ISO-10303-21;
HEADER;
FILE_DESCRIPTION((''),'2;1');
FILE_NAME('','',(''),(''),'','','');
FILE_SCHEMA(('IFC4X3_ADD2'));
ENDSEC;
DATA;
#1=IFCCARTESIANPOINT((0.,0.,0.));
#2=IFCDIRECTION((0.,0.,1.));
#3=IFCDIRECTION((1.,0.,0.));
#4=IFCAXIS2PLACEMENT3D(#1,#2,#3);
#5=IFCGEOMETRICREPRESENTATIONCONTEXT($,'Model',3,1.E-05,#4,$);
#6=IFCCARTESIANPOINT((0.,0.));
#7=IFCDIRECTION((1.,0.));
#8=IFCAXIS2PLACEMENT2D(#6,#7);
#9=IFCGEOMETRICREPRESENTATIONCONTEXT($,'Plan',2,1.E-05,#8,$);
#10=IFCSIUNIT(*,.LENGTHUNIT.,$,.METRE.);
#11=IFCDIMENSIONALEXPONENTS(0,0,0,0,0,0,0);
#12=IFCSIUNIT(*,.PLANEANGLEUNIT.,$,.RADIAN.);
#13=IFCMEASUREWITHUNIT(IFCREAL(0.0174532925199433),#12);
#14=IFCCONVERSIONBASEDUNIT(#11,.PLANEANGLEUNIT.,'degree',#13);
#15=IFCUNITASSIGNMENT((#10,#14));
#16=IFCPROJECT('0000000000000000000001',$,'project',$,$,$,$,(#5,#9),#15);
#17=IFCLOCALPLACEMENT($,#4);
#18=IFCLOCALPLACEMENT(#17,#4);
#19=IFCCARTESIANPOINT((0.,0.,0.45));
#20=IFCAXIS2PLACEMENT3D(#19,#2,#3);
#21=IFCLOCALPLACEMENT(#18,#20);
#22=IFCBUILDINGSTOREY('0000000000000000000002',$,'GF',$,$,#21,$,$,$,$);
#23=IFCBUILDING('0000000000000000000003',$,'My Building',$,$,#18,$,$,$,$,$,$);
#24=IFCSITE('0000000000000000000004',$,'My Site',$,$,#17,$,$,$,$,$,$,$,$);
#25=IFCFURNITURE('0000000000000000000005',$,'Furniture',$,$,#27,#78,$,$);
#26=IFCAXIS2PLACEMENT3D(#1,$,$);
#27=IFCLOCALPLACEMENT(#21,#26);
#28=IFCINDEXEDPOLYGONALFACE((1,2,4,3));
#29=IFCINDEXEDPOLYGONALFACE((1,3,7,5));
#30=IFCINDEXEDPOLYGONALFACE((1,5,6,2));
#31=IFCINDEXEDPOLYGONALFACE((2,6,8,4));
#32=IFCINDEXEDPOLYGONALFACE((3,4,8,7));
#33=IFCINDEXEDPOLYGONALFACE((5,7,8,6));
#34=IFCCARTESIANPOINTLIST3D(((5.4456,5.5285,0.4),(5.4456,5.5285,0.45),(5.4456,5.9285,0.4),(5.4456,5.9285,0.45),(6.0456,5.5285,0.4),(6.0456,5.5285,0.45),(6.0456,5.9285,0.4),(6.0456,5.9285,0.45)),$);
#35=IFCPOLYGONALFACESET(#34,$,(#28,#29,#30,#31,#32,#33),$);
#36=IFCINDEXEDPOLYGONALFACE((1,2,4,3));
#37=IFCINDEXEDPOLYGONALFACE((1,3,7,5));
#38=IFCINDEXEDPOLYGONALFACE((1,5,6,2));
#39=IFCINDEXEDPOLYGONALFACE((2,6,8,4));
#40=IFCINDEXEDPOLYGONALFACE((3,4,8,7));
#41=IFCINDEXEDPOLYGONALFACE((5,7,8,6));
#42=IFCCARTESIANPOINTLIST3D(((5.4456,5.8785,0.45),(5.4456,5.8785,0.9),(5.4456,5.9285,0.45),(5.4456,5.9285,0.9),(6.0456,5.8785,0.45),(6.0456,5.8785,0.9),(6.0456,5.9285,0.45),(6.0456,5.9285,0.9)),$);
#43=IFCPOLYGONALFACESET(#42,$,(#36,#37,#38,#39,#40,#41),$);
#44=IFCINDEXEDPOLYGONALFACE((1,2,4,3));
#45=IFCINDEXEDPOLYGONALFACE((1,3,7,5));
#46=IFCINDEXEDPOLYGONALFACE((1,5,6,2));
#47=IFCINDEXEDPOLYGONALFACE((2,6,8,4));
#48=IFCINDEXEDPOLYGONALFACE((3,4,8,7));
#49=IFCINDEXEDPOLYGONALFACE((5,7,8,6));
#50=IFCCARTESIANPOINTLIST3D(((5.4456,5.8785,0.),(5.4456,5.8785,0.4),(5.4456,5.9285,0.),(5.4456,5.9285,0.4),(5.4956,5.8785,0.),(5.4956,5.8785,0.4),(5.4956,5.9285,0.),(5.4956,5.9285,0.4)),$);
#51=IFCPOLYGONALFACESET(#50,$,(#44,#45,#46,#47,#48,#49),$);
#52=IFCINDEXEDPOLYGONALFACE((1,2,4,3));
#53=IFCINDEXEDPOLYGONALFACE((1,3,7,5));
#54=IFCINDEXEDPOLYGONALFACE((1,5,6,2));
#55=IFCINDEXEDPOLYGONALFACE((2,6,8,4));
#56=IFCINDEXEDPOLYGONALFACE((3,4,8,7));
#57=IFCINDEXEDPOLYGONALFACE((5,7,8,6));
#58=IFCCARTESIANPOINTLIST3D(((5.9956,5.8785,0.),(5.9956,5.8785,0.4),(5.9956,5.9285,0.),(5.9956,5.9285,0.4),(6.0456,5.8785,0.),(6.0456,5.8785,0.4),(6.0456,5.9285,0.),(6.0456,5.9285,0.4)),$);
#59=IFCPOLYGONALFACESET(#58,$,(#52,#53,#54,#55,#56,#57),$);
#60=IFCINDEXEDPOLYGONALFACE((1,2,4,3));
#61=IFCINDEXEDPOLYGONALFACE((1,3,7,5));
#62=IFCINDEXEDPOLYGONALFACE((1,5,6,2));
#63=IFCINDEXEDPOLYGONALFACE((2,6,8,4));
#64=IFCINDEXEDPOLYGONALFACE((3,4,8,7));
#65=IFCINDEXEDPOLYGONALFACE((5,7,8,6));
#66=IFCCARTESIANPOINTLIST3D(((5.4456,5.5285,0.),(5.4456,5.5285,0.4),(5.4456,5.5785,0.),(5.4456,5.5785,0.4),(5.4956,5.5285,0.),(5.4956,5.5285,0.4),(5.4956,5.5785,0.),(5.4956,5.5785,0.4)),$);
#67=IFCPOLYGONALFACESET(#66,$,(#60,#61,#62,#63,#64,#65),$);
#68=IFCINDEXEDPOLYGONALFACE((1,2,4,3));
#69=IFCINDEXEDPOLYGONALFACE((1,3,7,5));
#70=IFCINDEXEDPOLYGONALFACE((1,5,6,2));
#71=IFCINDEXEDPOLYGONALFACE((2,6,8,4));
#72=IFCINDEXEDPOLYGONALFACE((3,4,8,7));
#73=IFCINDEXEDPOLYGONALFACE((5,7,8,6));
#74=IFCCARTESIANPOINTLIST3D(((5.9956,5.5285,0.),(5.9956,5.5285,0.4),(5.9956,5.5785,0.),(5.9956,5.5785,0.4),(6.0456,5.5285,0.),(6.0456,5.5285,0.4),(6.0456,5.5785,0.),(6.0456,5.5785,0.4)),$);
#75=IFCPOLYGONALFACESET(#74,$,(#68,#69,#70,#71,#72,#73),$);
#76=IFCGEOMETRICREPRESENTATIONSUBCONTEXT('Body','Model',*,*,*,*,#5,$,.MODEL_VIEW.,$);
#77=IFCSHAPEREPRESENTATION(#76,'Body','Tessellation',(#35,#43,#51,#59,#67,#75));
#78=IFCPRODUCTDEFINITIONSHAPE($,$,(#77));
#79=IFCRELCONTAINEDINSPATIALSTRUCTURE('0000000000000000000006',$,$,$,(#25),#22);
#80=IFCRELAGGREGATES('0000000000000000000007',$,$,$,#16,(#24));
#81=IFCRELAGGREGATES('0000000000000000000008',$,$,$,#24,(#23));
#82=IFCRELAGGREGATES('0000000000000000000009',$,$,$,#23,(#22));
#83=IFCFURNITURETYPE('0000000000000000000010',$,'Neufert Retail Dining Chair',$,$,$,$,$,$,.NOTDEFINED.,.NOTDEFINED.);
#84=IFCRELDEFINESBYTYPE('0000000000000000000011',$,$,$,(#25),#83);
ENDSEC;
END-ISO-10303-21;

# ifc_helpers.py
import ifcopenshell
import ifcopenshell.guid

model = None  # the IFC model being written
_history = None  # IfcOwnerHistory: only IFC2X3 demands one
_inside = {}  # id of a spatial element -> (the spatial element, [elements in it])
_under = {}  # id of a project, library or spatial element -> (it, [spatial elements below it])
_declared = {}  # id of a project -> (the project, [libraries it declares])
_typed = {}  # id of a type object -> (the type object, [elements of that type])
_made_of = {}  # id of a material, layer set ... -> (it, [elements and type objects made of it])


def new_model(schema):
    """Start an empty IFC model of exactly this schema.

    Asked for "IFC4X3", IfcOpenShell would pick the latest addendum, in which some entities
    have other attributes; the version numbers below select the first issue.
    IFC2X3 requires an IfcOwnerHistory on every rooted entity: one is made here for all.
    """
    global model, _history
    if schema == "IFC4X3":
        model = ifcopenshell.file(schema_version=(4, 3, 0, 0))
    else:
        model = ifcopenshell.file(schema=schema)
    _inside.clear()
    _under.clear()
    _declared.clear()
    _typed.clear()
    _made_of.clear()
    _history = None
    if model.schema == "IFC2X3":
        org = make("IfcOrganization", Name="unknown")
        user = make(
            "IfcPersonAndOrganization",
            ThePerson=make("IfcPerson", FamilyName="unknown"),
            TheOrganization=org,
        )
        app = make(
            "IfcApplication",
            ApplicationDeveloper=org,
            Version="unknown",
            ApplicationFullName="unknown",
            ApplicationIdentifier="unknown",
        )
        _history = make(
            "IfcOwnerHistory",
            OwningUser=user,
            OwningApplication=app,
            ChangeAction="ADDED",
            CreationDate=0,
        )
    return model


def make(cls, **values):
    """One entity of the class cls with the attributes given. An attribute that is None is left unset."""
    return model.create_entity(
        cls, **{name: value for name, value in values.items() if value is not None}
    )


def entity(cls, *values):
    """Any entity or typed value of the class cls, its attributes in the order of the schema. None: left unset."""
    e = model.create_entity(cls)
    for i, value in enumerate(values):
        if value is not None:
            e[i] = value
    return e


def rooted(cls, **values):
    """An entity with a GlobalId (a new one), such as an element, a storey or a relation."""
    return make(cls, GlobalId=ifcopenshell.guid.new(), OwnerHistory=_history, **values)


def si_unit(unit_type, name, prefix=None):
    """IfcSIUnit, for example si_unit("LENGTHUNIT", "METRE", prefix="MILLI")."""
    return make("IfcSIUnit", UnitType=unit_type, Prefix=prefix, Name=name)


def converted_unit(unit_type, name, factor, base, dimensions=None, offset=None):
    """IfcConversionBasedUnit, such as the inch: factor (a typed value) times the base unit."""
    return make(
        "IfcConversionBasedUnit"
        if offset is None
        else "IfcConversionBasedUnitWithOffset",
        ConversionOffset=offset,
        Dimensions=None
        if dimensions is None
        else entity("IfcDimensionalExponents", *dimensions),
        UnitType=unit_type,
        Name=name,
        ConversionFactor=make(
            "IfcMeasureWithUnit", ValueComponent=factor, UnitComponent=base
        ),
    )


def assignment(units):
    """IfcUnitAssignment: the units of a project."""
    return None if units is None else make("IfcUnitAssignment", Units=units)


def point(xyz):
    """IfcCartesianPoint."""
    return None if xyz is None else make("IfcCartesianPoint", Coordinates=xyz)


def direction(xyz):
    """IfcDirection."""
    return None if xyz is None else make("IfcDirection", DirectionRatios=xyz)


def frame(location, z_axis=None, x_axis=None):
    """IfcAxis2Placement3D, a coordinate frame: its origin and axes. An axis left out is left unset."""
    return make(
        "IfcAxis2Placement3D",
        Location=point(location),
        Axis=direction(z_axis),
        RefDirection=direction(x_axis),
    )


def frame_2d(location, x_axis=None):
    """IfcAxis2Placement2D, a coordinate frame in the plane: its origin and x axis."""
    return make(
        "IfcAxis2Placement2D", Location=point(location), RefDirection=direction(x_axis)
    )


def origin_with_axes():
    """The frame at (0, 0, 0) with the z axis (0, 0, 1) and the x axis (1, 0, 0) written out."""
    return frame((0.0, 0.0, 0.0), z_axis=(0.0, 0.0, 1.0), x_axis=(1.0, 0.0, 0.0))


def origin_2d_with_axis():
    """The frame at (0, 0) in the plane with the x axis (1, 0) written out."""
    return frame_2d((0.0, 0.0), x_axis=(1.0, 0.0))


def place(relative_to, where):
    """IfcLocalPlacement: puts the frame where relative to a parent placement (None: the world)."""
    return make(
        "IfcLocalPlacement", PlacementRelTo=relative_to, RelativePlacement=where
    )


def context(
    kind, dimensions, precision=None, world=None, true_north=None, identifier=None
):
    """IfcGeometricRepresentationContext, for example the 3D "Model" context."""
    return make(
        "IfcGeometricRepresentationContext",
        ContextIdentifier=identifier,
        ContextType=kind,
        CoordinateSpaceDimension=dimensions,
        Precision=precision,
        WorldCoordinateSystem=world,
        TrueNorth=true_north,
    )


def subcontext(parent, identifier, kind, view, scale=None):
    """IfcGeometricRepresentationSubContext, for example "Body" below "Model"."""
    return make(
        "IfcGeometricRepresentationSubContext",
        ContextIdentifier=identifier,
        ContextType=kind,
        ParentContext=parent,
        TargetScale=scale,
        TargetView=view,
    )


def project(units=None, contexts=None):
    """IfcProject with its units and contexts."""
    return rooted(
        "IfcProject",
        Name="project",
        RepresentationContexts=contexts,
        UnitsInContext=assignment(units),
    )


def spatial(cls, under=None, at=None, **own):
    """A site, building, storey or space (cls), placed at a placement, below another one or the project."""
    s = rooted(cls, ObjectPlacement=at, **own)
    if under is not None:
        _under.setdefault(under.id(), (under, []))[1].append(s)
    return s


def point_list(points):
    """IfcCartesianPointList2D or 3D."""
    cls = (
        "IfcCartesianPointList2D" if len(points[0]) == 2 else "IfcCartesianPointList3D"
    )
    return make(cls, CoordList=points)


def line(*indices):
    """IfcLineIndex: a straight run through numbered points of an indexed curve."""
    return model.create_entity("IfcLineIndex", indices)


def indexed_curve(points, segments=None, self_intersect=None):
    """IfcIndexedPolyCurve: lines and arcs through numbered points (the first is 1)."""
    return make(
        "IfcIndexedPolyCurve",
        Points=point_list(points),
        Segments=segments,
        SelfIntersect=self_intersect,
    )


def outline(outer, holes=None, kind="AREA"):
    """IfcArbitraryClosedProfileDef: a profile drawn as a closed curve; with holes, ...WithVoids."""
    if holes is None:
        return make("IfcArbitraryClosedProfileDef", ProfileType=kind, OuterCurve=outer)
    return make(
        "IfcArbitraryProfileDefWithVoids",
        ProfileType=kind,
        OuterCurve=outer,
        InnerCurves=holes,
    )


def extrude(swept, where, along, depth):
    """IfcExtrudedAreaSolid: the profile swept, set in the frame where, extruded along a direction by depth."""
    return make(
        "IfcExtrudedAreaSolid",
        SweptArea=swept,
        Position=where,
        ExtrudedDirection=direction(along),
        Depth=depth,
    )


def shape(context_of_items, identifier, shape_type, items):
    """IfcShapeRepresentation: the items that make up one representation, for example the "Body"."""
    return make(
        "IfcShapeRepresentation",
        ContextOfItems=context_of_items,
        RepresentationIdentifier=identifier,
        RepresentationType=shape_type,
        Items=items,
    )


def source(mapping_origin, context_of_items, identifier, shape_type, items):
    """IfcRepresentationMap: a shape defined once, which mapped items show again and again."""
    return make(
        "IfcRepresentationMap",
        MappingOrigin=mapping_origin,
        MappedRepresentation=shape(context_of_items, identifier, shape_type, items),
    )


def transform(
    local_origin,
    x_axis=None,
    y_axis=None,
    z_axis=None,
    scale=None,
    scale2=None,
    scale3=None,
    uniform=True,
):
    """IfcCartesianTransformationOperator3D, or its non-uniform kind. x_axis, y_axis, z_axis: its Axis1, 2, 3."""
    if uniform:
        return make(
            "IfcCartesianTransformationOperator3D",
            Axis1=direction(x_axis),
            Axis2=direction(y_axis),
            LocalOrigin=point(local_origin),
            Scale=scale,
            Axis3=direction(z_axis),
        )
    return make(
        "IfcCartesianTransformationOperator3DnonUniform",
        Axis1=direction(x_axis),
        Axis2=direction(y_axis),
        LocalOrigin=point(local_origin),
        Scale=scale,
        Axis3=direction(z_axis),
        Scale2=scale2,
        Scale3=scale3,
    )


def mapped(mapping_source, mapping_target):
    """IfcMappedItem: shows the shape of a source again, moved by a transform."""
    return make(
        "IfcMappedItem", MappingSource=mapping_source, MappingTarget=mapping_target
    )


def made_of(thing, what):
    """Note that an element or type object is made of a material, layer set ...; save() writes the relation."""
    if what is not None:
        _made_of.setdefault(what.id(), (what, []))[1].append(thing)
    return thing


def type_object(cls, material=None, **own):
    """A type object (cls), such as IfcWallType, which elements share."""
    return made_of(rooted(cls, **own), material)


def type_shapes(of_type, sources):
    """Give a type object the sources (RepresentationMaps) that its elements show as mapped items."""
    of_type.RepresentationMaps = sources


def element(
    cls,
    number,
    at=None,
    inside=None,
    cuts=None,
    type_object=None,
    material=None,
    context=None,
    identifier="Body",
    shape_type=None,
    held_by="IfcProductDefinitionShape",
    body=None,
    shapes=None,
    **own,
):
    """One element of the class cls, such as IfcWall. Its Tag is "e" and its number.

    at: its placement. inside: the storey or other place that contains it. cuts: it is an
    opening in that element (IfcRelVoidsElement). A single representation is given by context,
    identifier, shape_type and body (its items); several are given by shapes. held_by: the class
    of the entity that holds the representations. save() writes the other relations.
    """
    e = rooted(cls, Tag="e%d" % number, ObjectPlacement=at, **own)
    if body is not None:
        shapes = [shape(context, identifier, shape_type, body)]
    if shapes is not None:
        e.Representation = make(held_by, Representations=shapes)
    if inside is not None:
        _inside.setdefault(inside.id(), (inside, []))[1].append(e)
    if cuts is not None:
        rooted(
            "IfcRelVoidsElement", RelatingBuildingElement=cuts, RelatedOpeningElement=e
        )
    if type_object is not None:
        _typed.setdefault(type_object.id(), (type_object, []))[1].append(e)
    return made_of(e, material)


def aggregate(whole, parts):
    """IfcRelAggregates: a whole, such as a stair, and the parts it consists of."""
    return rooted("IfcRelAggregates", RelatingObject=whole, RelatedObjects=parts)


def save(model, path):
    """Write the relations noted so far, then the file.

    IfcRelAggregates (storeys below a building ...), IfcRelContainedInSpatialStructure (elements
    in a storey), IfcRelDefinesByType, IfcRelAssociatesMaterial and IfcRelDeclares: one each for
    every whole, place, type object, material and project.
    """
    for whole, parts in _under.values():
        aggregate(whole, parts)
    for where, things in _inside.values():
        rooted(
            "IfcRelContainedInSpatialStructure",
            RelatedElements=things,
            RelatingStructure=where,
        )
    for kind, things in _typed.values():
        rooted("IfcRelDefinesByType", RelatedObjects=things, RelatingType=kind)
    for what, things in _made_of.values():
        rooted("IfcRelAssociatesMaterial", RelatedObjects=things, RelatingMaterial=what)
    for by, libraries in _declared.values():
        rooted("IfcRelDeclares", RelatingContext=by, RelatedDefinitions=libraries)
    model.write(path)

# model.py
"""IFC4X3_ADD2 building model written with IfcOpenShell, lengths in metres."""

from ifc_helpers import new_model, entity, si_unit, converted_unit, frame, origin_with_axes, origin_2d_with_axis, place, context, subcontext, project, spatial, line, indexed_curve, outline, extrude, shape, source, transform, mapped, type_object, type_shapes, element, save


model = new_model("IFC4X3_ADD2")

# Units and contexts
model_context = context("Model", 3, precision=1e-05, world=origin_with_axes())
plan_context = context("Plan", 2, precision=1e-05, world=origin_2d_with_axis())
body_context_1 = subcontext(model_context, "Body", "Model", "MODEL_VIEW")
body_context_2 = subcontext(plan_context, "Body", "Plan", "PLAN_VIEW")
ifc_project = project(units=[si_unit("LENGTHUNIT", "METRE"), converted_unit("PLANEANGLEUNIT", "degree", entity("IfcReal", 0.0174532925199433), si_unit("PLANEANGLEUNIT", "RADIAN"), dimensions=[0, 0, 0, 0, 0, 0, 0])], contexts=[model_context, plan_context])

# Site, building, storey
site_placement = place(None, origin_with_axes())
site = spatial("IfcSite", under=ifc_project, at=site_placement, Name="My Site")
building_placement = place(site_placement, origin_with_axes())
building = spatial("IfcBuilding", under=site, at=building_placement, Name="My Building")
storey_placement = place(building_placement, frame((0.0, 0.0, 0.45), z_axis=(0.0, 0.0, 1.0), x_axis=(1.0, 0.0, 0.0)))
storey = spatial("IfcBuildingStorey", under=building, at=storey_placement, Name="GF")

# Furniture
furniture_type = type_object("IfcFurnitureType", Name="Neufert Retail Dining Chair", AssemblyPlace="NOTDEFINED", PredefinedType="NOTDEFINED")
shared_shape_1 = source(origin_with_axes(), body_context_1, "Body", "SweptSolid", [
    extrude(outline(indexed_curve([(-0.3, 0.0), (0.3, 0.0), (0.3, -0.4), (-0.3, -0.4)], segments=[line(1, 2, 3, 4, 1)])), frame((0.0, 0.0, 0.45), z_axis=(0.0, 0.0, 1.0), x_axis=(1.0, 0.0, 0.0)), (0.0, 0.0, -1.0), 0.05),
    extrude(outline(indexed_curve([(-0.3, 0.0), (0.3, 0.0), (0.3, -0.05), (-0.3, -0.05)], segments=[line(1, 2, 3, 4, 1)])), frame((0.0, 0.0, 0.9), z_axis=(0.0, 0.0, 1.0), x_axis=(1.0, 0.0, 0.0)), (0.0, 0.0, -1.0), 0.45),
    extrude(outline(indexed_curve([(-0.3, 0.0), (-0.25, 0.0), (-0.25, -0.05), (-0.3, -0.05)], segments=[line(1, 2, 3, 4, 1)])), origin_with_axes(), (0.0, 0.0, 1.0), 0.4),
    extrude(outline(indexed_curve([(0.3, 0.0), (0.25, 0.0), (0.25, -0.05), (0.3, -0.05)], segments=[line(1, 2, 3, 4, 1)])), origin_with_axes(), (0.0, 0.0, 1.0), 0.4),
    extrude(outline(indexed_curve([(-0.3, -0.4), (-0.25, -0.4), (-0.25, -0.35), (-0.3, -0.35)], segments=[line(1, 2, 3, 4, 1)])), origin_with_axes(), (0.0, 0.0, 1.0), 0.4),
    extrude(outline(indexed_curve([(0.3, -0.4), (0.25, -0.4), (0.25, -0.35), (0.3, -0.35)], segments=[line(1, 2, 3, 4, 1)])), origin_with_axes(), (0.0, 0.0, 1.0), 0.4),
])
shared_shape_2 = source(origin_with_axes(), body_context_2, "Body", "Curve2D", [
    entity("IfcIndexedPolyCurve", entity("IfcCartesianPointList2D", [[-0.3, -0.4], [0.3, -0.4]])),
    entity("IfcIndexedPolyCurve", entity("IfcCartesianPointList2D", [[-0.3, -0.4], [-0.3, -0.3], [-0.2121, -0.0879], [0.0, 0.0], [0.2121, -0.0879], [0.3, -0.3], [0.3, -0.4]]), [entity("IfcLineIndex", [1, 2]), entity("IfcArcIndex", [2, 3, 4]), entity("IfcArcIndex", [4, 5, 6]), entity("IfcLineIndex", [6, 7])]),
    entity("IfcIndexedPolyCurve", entity("IfcCartesianPointList2D", [[-0.26, -0.4], [-0.26, -0.3], [-0.1838, -0.1162], [0.0, -0.04], [0.1838, -0.1162], [0.26, -0.3], [0.26, -0.4]]), [entity("IfcLineIndex", [1, 2]), entity("IfcArcIndex", [2, 3, 4]), entity("IfcArcIndex", [4, 5, 6]), entity("IfcLineIndex", [6, 7])]),
])
type_shapes(furniture_type, [shared_shape_1, shared_shape_2])
furniture_placement = place(storey_placement, frame((5.7456, 5.9285, 0.0), z_axis=(0.0, 0.0, 1.0), x_axis=(1.0, -0.000001, 0.0)))
element("IfcFurniture", 1, at=furniture_placement, inside=storey, type_object=furniture_type, Name="Furniture", shapes=[
    shape(body_context_1, "Body", "MappedRepresentation", [mapped(shared_shape_1, transform((0.0, 0.0, 0.0), x_axis=(1.0, 0.0, 0.0), y_axis=(0.0, 1.0, 0.0), z_axis=(0.0, 0.0, 1.0), scale=1.0))]),
    shape(body_context_2, "Body", "MappedRepresentation", [mapped(shared_shape_2, transform((0.0, 0.0, 0.0), x_axis=(1.0, 0.0, 0.0), y_axis=(0.0, 1.0, 0.0), z_axis=(0.0, 0.0, 1.0), scale=1.0))]),
])

save(model, "model.ifc")
